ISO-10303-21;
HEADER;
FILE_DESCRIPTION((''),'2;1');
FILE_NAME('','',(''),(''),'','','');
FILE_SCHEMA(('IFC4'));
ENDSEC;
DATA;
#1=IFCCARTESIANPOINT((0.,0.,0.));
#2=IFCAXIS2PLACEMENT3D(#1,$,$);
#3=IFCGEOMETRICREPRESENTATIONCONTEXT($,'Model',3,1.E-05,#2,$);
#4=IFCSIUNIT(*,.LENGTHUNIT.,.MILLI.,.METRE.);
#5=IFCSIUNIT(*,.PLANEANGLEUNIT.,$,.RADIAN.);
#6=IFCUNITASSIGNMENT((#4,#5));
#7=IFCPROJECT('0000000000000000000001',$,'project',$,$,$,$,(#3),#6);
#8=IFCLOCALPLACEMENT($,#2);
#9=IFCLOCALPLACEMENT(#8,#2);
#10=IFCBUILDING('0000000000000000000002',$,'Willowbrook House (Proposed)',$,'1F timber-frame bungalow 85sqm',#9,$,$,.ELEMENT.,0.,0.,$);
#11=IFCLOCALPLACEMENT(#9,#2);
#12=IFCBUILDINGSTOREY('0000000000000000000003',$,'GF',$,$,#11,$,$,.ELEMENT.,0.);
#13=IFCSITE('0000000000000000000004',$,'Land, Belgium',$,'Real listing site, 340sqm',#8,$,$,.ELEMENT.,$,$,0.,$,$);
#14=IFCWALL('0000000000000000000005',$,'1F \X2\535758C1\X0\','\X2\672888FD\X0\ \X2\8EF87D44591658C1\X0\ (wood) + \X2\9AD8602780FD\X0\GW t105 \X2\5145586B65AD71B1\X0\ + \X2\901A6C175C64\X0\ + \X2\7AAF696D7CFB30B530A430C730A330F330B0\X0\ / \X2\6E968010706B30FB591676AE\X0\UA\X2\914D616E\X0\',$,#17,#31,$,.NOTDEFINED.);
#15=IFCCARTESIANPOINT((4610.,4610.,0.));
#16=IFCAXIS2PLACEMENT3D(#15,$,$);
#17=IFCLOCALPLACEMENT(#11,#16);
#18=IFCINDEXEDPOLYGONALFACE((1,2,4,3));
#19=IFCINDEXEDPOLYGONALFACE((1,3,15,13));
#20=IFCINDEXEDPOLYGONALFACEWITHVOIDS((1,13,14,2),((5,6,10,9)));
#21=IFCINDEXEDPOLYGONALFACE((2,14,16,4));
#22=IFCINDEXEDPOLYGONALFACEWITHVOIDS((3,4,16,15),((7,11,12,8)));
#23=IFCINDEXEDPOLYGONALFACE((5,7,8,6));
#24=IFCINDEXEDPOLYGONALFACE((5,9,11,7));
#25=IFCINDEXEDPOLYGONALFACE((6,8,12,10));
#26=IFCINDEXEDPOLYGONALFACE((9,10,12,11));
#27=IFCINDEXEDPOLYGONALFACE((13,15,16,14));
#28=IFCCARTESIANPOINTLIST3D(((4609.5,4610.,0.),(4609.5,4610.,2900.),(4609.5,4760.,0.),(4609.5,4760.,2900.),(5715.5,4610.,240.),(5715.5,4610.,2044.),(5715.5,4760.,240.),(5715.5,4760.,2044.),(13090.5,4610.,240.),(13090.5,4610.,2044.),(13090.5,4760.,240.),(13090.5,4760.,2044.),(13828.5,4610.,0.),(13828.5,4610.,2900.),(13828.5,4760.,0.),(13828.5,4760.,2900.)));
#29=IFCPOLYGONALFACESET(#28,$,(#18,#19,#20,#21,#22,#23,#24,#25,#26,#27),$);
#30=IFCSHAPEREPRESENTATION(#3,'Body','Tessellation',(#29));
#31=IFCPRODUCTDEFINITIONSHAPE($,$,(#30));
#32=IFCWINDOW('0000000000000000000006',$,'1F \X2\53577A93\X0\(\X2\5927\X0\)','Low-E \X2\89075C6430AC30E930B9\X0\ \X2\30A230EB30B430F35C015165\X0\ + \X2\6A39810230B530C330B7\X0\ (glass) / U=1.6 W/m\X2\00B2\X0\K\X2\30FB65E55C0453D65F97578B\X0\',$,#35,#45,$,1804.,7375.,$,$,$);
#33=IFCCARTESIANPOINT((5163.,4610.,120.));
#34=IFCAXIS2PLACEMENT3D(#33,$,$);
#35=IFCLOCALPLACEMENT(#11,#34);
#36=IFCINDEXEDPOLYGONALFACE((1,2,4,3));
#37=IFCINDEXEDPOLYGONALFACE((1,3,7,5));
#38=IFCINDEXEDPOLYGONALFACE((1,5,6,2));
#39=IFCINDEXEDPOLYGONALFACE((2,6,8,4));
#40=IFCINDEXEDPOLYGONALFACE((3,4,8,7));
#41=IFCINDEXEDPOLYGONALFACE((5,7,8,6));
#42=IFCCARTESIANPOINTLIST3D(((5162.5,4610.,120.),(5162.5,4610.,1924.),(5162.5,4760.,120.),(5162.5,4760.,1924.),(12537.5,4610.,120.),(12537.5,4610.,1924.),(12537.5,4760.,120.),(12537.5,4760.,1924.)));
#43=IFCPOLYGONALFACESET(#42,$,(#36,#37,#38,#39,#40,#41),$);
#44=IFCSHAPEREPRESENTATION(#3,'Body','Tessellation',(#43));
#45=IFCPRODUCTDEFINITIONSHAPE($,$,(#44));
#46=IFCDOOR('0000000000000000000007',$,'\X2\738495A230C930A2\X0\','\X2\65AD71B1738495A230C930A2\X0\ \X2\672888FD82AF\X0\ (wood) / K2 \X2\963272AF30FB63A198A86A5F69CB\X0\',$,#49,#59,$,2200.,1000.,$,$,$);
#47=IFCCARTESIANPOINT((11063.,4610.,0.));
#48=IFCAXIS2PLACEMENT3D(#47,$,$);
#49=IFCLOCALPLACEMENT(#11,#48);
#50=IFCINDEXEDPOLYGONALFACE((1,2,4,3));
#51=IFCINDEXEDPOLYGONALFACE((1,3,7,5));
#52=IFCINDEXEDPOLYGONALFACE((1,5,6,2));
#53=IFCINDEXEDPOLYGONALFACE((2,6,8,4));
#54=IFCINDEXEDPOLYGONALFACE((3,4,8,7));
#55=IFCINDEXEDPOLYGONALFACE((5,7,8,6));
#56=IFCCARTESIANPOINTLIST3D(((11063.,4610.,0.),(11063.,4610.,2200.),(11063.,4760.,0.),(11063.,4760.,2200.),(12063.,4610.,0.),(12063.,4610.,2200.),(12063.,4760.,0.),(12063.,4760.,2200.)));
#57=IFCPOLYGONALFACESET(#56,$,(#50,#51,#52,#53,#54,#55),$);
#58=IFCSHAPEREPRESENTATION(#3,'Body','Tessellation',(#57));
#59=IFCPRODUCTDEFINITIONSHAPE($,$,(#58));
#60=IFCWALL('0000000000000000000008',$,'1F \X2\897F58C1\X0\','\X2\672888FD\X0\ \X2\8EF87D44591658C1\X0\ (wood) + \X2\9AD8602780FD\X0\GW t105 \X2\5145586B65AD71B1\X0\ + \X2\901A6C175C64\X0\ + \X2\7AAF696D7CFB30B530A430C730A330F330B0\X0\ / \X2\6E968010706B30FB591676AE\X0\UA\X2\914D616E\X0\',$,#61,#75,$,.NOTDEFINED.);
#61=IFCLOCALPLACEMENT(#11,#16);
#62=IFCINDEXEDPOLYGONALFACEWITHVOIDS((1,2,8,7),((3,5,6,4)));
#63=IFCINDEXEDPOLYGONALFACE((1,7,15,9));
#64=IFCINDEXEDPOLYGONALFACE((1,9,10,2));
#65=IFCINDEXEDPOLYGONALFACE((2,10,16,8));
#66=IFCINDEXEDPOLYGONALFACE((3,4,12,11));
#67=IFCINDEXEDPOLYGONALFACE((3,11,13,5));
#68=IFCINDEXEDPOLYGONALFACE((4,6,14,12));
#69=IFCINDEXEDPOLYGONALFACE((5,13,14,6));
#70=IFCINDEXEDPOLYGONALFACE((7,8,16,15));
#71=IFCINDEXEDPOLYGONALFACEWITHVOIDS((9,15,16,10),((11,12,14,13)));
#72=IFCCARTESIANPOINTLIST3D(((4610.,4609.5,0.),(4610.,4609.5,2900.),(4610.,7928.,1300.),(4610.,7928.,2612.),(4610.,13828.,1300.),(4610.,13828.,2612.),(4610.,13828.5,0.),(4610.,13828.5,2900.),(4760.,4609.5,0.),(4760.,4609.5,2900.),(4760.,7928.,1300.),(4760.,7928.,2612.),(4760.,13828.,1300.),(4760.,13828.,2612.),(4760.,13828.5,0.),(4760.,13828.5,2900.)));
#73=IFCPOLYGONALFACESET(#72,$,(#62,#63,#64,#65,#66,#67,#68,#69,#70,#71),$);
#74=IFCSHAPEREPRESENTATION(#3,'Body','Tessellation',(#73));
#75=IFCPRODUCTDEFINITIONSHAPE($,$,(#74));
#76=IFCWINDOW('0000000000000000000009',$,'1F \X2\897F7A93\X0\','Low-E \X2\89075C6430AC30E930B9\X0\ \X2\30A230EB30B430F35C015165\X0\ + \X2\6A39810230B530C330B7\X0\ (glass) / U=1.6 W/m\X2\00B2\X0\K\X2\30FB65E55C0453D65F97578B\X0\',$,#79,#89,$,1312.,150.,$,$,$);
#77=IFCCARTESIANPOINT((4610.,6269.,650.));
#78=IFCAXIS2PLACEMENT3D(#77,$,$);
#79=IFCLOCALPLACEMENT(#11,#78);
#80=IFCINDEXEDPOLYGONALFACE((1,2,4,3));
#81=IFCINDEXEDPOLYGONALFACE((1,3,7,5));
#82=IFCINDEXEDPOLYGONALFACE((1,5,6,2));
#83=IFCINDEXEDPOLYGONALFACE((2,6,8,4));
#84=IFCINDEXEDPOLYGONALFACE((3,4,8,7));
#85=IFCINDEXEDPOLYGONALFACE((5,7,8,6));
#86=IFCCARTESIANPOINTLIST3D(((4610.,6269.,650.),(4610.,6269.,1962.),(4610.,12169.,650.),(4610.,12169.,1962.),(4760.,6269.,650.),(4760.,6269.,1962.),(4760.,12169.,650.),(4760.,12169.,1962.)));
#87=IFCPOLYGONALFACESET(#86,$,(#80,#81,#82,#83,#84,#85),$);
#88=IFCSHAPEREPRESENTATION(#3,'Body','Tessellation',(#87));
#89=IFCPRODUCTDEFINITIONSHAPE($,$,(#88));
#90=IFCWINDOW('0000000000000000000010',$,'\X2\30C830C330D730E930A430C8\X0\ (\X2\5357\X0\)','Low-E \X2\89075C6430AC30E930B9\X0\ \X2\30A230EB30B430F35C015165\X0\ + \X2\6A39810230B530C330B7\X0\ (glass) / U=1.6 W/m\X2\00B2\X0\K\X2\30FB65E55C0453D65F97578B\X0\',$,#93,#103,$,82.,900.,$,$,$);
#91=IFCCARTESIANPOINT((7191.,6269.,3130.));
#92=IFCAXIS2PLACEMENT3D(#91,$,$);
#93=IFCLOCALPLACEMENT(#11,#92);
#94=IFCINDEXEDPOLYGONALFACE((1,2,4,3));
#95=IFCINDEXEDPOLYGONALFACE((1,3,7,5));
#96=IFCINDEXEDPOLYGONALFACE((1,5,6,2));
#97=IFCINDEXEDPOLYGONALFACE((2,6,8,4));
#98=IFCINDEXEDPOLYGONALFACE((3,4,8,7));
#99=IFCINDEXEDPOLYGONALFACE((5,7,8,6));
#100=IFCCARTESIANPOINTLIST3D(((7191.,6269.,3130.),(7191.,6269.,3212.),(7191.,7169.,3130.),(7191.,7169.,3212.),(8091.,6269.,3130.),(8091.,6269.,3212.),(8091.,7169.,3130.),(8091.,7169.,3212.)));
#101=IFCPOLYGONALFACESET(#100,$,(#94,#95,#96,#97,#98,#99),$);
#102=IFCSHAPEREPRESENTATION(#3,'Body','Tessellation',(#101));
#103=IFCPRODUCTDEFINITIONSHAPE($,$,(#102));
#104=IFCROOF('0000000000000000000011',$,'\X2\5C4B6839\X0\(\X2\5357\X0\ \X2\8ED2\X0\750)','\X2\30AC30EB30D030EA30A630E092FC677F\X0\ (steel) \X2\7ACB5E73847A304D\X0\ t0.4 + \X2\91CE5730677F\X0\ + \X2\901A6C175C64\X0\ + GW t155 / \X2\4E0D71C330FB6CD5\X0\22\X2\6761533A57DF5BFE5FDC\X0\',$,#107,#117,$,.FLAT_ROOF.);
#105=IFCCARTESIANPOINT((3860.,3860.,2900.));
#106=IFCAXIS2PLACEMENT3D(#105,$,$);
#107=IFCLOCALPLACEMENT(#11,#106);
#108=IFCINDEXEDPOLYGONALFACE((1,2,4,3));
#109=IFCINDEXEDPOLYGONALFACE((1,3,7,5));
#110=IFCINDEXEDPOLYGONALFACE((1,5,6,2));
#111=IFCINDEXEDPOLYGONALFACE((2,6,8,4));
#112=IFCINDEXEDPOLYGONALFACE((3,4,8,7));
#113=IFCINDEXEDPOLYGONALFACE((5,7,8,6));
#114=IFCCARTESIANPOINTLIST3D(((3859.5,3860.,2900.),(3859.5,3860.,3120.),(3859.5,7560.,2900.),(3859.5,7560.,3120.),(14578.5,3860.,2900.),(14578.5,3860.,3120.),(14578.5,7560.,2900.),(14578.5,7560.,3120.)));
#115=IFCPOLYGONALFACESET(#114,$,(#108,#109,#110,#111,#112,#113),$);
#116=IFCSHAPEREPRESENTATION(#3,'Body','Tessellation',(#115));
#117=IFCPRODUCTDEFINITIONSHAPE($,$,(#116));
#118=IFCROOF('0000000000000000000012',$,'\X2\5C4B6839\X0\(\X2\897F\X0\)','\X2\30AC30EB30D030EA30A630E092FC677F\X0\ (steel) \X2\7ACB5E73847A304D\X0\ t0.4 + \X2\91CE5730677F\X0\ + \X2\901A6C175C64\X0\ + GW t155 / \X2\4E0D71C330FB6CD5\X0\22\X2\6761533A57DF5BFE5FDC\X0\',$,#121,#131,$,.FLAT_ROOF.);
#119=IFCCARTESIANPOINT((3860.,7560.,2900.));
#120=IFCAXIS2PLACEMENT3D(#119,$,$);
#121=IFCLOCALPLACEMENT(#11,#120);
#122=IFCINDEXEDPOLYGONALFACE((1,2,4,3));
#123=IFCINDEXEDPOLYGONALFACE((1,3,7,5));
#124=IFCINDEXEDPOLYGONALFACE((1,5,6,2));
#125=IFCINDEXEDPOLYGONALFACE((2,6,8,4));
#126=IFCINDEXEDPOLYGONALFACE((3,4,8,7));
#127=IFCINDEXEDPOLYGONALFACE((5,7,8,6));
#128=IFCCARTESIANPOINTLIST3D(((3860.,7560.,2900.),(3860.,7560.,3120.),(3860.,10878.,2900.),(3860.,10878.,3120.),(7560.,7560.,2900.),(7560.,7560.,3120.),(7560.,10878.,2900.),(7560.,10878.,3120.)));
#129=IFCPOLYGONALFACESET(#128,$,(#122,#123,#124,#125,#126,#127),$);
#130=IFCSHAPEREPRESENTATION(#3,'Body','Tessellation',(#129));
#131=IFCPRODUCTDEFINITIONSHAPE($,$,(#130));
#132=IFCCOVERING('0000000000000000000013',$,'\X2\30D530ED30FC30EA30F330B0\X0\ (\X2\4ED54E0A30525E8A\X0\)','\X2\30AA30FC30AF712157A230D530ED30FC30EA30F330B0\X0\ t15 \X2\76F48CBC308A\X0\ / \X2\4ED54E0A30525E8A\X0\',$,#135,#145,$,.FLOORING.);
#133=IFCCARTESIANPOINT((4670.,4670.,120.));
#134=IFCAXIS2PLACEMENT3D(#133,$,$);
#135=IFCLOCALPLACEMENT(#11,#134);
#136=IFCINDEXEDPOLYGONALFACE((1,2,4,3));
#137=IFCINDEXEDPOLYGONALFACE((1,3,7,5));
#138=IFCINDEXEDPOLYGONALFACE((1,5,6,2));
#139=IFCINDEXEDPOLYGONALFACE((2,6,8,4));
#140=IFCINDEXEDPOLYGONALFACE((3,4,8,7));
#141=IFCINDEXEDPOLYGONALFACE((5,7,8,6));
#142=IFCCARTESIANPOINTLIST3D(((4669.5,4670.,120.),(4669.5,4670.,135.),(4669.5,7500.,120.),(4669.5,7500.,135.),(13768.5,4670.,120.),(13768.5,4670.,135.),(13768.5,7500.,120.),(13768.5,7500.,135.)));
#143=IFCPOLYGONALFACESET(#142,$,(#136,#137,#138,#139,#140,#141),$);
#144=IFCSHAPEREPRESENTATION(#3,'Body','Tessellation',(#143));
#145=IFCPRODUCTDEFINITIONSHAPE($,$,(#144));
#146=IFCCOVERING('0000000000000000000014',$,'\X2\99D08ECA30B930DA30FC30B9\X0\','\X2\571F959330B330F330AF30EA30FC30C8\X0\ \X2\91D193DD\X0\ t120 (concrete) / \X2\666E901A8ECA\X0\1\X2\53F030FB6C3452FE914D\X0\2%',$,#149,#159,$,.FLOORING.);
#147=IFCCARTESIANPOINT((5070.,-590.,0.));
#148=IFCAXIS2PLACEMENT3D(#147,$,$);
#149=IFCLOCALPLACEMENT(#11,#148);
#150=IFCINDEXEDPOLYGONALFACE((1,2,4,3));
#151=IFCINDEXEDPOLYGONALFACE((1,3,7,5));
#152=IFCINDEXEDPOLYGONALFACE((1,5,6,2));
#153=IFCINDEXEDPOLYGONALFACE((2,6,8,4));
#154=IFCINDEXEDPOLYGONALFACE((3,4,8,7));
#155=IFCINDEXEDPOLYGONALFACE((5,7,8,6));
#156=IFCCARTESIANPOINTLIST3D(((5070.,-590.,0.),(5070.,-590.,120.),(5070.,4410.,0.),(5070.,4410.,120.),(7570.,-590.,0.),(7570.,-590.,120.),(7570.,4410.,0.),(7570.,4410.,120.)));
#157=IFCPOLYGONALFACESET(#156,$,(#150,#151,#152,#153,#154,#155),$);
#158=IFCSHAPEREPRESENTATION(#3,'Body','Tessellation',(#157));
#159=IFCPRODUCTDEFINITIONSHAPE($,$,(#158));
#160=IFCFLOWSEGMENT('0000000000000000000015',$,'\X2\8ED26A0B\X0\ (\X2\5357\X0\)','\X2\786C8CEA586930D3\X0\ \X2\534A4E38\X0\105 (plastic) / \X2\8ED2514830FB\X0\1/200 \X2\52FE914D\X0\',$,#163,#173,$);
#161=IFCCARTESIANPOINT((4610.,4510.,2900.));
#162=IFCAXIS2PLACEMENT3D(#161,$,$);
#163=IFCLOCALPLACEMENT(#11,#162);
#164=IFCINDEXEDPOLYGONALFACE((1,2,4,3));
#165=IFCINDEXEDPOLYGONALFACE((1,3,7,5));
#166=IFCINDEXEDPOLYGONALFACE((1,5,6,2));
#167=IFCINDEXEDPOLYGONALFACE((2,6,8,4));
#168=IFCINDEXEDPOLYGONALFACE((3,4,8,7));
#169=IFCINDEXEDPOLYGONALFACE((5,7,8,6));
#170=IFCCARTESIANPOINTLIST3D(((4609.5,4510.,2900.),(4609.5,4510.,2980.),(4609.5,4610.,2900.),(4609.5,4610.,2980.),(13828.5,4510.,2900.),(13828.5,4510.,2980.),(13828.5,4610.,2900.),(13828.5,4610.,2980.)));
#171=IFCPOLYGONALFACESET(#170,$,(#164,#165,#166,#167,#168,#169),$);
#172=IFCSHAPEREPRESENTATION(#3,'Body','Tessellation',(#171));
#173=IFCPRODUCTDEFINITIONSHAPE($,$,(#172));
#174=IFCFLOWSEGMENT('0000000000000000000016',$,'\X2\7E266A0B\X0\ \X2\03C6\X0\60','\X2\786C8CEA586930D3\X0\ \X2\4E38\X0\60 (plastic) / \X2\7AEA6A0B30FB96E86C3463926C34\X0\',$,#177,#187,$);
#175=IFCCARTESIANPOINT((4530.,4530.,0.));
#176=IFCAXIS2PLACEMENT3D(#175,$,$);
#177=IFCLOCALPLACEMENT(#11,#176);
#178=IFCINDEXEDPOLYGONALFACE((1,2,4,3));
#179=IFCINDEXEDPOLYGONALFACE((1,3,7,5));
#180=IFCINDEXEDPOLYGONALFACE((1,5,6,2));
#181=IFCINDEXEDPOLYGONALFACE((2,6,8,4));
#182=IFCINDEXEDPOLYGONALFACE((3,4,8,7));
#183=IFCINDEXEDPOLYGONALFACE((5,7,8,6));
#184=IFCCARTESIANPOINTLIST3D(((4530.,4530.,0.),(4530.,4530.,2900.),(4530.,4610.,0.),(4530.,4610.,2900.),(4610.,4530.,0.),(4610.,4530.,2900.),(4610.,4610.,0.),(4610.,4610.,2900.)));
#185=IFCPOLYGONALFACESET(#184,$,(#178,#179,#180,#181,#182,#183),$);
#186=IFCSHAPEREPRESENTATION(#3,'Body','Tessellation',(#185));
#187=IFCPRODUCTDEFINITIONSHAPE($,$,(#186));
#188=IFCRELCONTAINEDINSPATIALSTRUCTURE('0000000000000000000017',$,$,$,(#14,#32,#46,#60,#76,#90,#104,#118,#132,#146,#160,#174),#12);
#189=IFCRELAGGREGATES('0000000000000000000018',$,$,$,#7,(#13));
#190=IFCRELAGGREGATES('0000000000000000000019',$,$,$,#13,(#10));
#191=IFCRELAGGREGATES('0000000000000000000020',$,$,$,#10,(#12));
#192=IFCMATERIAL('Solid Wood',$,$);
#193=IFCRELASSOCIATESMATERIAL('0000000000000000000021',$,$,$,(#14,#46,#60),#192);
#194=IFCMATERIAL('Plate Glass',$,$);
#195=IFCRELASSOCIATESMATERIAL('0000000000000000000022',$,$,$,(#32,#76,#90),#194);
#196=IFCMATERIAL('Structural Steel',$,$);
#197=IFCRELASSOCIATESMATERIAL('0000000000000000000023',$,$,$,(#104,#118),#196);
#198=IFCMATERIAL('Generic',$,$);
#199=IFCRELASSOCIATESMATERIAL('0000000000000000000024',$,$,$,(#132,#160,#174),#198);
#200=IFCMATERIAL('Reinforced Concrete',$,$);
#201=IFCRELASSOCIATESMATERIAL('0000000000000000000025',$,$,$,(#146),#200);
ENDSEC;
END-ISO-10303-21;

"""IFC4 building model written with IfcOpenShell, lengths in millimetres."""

from ifc_helpers import new_model, si_unit, frame, frame_2d, origin, place, context, project, spatial, rectangle, extrude, material, element, fill, save


model = new_model("IFC4")

# Units and contexts
model_context = context("Model", 3, precision=1e-05, world=origin())
ifc_project = project(units=[si_unit("LENGTHUNIT", "METRE", prefix="MILLI"), si_unit("PLANEANGLEUNIT", "RADIAN")], contexts=[model_context])

# Site, building, storey
site_placement = place(None, origin())
site = spatial("IfcSite", under=ifc_project, at=site_placement, Name="Land, Belgium", ObjectType="Real listing site, 340sqm", CompositionType="ELEMENT", RefElevation=0.0)
building_placement = place(site_placement, origin())
building = spatial("IfcBuilding", under=site, at=building_placement, Name="Willowbrook House (Proposed)", ObjectType="1F timber-frame bungalow 85sqm", CompositionType="ELEMENT", ElevationOfRefHeight=0.0, ElevationOfTerrain=0.0)
storey_placement = place(building_placement, origin())
storey = spatial("IfcBuildingStorey", under=building, at=storey_placement, Name="GF", CompositionType="ELEMENT", Elevation=0.0)

# Shared definitions
ifc_material_1 = material(Name="Solid Wood")

# Shared definitions
ifc_material_2 = material(Name="Reinforced Concrete")

# Wall, openings, window, door
wall_1_placement = place(storey_placement, frame((4610.0, 4610.0, 0.0)))
wall_1 = element("IfcWall", 1, at=wall_1_placement, inside=storey, material=ifc_material_1, Name="1F 南壁", Description="木製 軸組外壁 (wood) + 高性能GW t105 充填断熱 + 通気層 + 窯業系サイディング / 準耐火・外皮UA配慮", PredefinedType="NOTDEFINED", context=model_context, shape_type="SweptSolid", body=[
    extrude(rectangle(XDim=9219.0, YDim=150.0, at=frame_2d((4609.0, 75.0))), frame((4610.0, 4610.0, 0.0)), (0.0, 0.0, 1.0), 2900.0),
])
opening_1_placement = place(storey_placement, frame((5163.0, 4610.0, 120.0)))
opening_1 = element("IfcOpeningElement", 2, at=opening_1_placement, cuts=wall_1, PredefinedType="NOTDEFINED", context=model_context, shape_type="SweptSolid", body=[
    extrude(rectangle(XDim=7375.0, YDim=150.0, at=frame_2d((3687.0, 75.0))), frame((5163.0, 4610.0, 120.0)), (0.0, 0.0, 1.0), 1804.0),
])
opening_2_placement = place(storey_placement, frame((11063.0, 4610.0, 0.0)))
opening_2 = element("IfcOpeningElement", 3, at=opening_2_placement, cuts=wall_1, PredefinedType="NOTDEFINED", context=model_context, shape_type="SweptSolid", body=[
    extrude(rectangle(XDim=1000.0, YDim=150.0, at=frame_2d((500.0, 75.0))), frame((11063.0, 4610.0, 0.0)), (0.0, 0.0, 1.0), 2200.0),
])
ifc_material_3 = material(Name="Plate Glass")
window_1_placement = place(storey_placement, frame((5163.0, 4610.0, 120.0)))
window_1 = element("IfcWindow", 4, at=window_1_placement, inside=storey, material=ifc_material_3, Name="1F 南窓(大)", Description="Low-E 複層ガラス アルゴン封入 + 樹脂サッシ (glass) / U=1.6 W/m²K・日射取得型", OverallHeight=1804.0, OverallWidth=7375.0, context=model_context, shape_type="SweptSolid", body=[
    extrude(rectangle(XDim=7375.0, YDim=150.0, at=frame_2d((3687.0, 75.0))), frame((5163.0, 4610.0, 120.0)), (0.0, 0.0, 1.0), 1804.0),
])
fill(opening_1, window_1)
door_placement = place(storey_placement, frame((11063.0, 4610.0, 0.0)))
door = element("IfcDoor", 5, at=door_placement, inside=storey, material=ifc_material_1, Name="玄関ドア", Description="断熱玄関ドア 木製芯 (wood) / K2 防犯・採風機構", OverallHeight=2200.0, OverallWidth=1000.0, context=model_context, shape_type="SweptSolid", body=[
    extrude(rectangle(XDim=1000.0, YDim=150.0, at=frame_2d((500.0, 75.0))), frame((11063.0, 4610.0, 0.0)), (0.0, 0.0, 1.0), 2200.0),
])
fill(opening_2, door)

# Wall, opening, window
wall_2_placement = place(storey_placement, frame((4610.0, 4610.0, 0.0)))
wall_2 = element("IfcWall", 6, at=wall_2_placement, inside=storey, material=ifc_material_1, Name="1F 西壁", Description="木製 軸組外壁 (wood) + 高性能GW t105 充填断熱 + 通気層 + 窯業系サイディング / 準耐火・外皮UA配慮", PredefinedType="NOTDEFINED", context=model_context, shape_type="SweptSolid", body=[
    extrude(rectangle(XDim=150.0, YDim=9219.0, at=frame_2d((75.0, 4609.0))), frame((4610.0, 4610.0, 0.0)), (0.0, 0.0, 1.0), 2900.0),
])
opening_3_placement = place(storey_placement, frame((4610.0, 6269.0, 650.0)))
opening_3 = element("IfcOpeningElement", 7, at=opening_3_placement, cuts=wall_2, PredefinedType="NOTDEFINED", context=model_context, shape_type="SweptSolid", body=[
    extrude(rectangle(XDim=150.0, YDim=5900.0, at=frame_2d((75.0, 2950.0))), frame((4610.0, 6269.0, 650.0)), (0.0, 0.0, 1.0), 1312.0),
])
window_2_placement = place(storey_placement, frame((4610.0, 6269.0, 650.0)))
window_2 = element("IfcWindow", 8, at=window_2_placement, inside=storey, material=ifc_material_3, Name="1F 西窓", Description="Low-E 複層ガラス アルゴン封入 + 樹脂サッシ (glass) / U=1.6 W/m²K・日射取得型", OverallHeight=1312.0, OverallWidth=150.0, context=model_context, shape_type="SweptSolid", body=[
    extrude(rectangle(XDim=150.0, YDim=5900.0, at=frame_2d((75.0, 2950.0))), frame((4610.0, 6269.0, 650.0)), (0.0, 0.0, 1.0), 1312.0),
])
fill(opening_3, window_2)

# Window
window_3_placement = place(storey_placement, frame((7191.0, 6269.0, 3130.0)))
element("IfcWindow", 9, at=window_3_placement, inside=storey, material=ifc_material_3, Name="トップライト (南)", Description="Low-E 複層ガラス アルゴン封入 + 樹脂サッシ (glass) / U=1.6 W/m²K・日射取得型", OverallHeight=82.0, OverallWidth=900.0, context=model_context, shape_type="SweptSolid", body=[
    extrude(rectangle(XDim=900.0, YDim=900.0, at=frame_2d((450.0, 450.0))), frame((7191.0, 6269.0, 3130.0)), (0.0, 0.0, 1.0), 82.0),
])

# Roofs
ifc_material_4 = material(Name="Structural Steel")
roof_1_placement = place(storey_placement, frame((3860.0, 3860.0, 2900.0)))
element("IfcRoof", 10, at=roof_1_placement, inside=storey, material=ifc_material_4, Name="屋根(南 軒750)", Description="ガルバリウム鋼板 (steel) 立平葺き t0.4 + 野地板 + 通気層 + GW t155 / 不燃・法22条区域対応", PredefinedType="FLAT_ROOF", context=model_context, shape_type="SweptSolid", body=[
    extrude(rectangle(XDim=10719.0, YDim=3700.0, at=frame_2d((5359.0, 1850.0))), frame((3860.0, 3860.0, 2900.0)), (0.0, 0.0, 1.0), 220.0),
])
roof_2_placement = place(storey_placement, frame((3860.0, 7560.0, 2900.0)))
element("IfcRoof", 11, at=roof_2_placement, inside=storey, material=ifc_material_4, Name="屋根(西)", Description="ガルバリウム鋼板 (steel) 立平葺き t0.4 + 野地板 + 通気層 + GW t155 / 不燃・法22条区域対応", PredefinedType="FLAT_ROOF", context=model_context, shape_type="SweptSolid", body=[
    extrude(rectangle(XDim=3700.0, YDim=3318.0, at=frame_2d((1850.0, 1659.0))), frame((3860.0, 7560.0, 2900.0)), (0.0, 0.0, 1.0), 220.0),
])

# Coverings
ifc_material_5 = material(Name="Generic")
covering_1_placement = place(storey_placement, frame((4670.0, 4670.0, 120.0)))
element("IfcCovering", 12, at=covering_1_placement, inside=storey, material=ifc_material_5, Name="フローリング (仕上げ床)", Description="オーク無垢フローリング t15 直貼り / 仕上げ床", PredefinedType="FLOORING", context=model_context, shape_type="SweptSolid", body=[
    extrude(rectangle(XDim=9099.0, YDim=2830.0, at=frame_2d((4549.0, 1415.0))), frame((4670.0, 4670.0, 120.0)), (0.0, 0.0, 1.0), 15.0),
])
covering_2_placement = place(storey_placement, frame((5070.0, -590.0, 0.0)))
element("IfcCovering", 13, at=covering_2_placement, inside=storey, material=ifc_material_2, Name="駐車スペース", Description="土間コンクリート 金鏝 t120 (concrete) / 普通車1台・水勾配2%", PredefinedType="FLOORING", context=model_context, shape_type="SweptSolid", body=[
    extrude(rectangle(XDim=2500.0, YDim=5000.0, at=frame_2d((1250.0, 2500.0))), frame((5070.0, -590.0, 0.0)), (0.0, 0.0, 1.0), 120.0),
])

# Flow segments
flow_segment_1_placement = place(storey_placement, frame((4610.0, 4510.0, 2900.0)))
element("IfcFlowSegment", 14, at=flow_segment_1_placement, inside=storey, material=ifc_material_5, Name="軒樋 (南)", Description="硬質塩ビ 半丸105 (plastic) / 軒先・1/200 勾配", context=model_context, shape_type="SweptSolid", body=[
    extrude(rectangle(XDim=9219.0, YDim=100.0, at=frame_2d((4609.0, 50.0))), frame((4610.0, 4510.0, 2900.0)), (0.0, 0.0, 1.0), 80.0),
])
flow_segment_2_placement = place(storey_placement, frame((4530.0, 4530.0, 0.0)))
element("IfcFlowSegment", 15, at=flow_segment_2_placement, inside=storey, material=ifc_material_5, Name="縦樋 φ60", Description="硬質塩ビ 丸60 (plastic) / 竪樋・雨水排水", context=model_context, shape_type="SweptSolid", body=[
    extrude(rectangle(XDim=80.0, YDim=80.0, at=frame_2d((40.0, 40.0))), frame((4530.0, 4530.0, 0.0)), (0.0, 0.0, 1.0), 2900.0),
])

save(model, "model.ifc")
